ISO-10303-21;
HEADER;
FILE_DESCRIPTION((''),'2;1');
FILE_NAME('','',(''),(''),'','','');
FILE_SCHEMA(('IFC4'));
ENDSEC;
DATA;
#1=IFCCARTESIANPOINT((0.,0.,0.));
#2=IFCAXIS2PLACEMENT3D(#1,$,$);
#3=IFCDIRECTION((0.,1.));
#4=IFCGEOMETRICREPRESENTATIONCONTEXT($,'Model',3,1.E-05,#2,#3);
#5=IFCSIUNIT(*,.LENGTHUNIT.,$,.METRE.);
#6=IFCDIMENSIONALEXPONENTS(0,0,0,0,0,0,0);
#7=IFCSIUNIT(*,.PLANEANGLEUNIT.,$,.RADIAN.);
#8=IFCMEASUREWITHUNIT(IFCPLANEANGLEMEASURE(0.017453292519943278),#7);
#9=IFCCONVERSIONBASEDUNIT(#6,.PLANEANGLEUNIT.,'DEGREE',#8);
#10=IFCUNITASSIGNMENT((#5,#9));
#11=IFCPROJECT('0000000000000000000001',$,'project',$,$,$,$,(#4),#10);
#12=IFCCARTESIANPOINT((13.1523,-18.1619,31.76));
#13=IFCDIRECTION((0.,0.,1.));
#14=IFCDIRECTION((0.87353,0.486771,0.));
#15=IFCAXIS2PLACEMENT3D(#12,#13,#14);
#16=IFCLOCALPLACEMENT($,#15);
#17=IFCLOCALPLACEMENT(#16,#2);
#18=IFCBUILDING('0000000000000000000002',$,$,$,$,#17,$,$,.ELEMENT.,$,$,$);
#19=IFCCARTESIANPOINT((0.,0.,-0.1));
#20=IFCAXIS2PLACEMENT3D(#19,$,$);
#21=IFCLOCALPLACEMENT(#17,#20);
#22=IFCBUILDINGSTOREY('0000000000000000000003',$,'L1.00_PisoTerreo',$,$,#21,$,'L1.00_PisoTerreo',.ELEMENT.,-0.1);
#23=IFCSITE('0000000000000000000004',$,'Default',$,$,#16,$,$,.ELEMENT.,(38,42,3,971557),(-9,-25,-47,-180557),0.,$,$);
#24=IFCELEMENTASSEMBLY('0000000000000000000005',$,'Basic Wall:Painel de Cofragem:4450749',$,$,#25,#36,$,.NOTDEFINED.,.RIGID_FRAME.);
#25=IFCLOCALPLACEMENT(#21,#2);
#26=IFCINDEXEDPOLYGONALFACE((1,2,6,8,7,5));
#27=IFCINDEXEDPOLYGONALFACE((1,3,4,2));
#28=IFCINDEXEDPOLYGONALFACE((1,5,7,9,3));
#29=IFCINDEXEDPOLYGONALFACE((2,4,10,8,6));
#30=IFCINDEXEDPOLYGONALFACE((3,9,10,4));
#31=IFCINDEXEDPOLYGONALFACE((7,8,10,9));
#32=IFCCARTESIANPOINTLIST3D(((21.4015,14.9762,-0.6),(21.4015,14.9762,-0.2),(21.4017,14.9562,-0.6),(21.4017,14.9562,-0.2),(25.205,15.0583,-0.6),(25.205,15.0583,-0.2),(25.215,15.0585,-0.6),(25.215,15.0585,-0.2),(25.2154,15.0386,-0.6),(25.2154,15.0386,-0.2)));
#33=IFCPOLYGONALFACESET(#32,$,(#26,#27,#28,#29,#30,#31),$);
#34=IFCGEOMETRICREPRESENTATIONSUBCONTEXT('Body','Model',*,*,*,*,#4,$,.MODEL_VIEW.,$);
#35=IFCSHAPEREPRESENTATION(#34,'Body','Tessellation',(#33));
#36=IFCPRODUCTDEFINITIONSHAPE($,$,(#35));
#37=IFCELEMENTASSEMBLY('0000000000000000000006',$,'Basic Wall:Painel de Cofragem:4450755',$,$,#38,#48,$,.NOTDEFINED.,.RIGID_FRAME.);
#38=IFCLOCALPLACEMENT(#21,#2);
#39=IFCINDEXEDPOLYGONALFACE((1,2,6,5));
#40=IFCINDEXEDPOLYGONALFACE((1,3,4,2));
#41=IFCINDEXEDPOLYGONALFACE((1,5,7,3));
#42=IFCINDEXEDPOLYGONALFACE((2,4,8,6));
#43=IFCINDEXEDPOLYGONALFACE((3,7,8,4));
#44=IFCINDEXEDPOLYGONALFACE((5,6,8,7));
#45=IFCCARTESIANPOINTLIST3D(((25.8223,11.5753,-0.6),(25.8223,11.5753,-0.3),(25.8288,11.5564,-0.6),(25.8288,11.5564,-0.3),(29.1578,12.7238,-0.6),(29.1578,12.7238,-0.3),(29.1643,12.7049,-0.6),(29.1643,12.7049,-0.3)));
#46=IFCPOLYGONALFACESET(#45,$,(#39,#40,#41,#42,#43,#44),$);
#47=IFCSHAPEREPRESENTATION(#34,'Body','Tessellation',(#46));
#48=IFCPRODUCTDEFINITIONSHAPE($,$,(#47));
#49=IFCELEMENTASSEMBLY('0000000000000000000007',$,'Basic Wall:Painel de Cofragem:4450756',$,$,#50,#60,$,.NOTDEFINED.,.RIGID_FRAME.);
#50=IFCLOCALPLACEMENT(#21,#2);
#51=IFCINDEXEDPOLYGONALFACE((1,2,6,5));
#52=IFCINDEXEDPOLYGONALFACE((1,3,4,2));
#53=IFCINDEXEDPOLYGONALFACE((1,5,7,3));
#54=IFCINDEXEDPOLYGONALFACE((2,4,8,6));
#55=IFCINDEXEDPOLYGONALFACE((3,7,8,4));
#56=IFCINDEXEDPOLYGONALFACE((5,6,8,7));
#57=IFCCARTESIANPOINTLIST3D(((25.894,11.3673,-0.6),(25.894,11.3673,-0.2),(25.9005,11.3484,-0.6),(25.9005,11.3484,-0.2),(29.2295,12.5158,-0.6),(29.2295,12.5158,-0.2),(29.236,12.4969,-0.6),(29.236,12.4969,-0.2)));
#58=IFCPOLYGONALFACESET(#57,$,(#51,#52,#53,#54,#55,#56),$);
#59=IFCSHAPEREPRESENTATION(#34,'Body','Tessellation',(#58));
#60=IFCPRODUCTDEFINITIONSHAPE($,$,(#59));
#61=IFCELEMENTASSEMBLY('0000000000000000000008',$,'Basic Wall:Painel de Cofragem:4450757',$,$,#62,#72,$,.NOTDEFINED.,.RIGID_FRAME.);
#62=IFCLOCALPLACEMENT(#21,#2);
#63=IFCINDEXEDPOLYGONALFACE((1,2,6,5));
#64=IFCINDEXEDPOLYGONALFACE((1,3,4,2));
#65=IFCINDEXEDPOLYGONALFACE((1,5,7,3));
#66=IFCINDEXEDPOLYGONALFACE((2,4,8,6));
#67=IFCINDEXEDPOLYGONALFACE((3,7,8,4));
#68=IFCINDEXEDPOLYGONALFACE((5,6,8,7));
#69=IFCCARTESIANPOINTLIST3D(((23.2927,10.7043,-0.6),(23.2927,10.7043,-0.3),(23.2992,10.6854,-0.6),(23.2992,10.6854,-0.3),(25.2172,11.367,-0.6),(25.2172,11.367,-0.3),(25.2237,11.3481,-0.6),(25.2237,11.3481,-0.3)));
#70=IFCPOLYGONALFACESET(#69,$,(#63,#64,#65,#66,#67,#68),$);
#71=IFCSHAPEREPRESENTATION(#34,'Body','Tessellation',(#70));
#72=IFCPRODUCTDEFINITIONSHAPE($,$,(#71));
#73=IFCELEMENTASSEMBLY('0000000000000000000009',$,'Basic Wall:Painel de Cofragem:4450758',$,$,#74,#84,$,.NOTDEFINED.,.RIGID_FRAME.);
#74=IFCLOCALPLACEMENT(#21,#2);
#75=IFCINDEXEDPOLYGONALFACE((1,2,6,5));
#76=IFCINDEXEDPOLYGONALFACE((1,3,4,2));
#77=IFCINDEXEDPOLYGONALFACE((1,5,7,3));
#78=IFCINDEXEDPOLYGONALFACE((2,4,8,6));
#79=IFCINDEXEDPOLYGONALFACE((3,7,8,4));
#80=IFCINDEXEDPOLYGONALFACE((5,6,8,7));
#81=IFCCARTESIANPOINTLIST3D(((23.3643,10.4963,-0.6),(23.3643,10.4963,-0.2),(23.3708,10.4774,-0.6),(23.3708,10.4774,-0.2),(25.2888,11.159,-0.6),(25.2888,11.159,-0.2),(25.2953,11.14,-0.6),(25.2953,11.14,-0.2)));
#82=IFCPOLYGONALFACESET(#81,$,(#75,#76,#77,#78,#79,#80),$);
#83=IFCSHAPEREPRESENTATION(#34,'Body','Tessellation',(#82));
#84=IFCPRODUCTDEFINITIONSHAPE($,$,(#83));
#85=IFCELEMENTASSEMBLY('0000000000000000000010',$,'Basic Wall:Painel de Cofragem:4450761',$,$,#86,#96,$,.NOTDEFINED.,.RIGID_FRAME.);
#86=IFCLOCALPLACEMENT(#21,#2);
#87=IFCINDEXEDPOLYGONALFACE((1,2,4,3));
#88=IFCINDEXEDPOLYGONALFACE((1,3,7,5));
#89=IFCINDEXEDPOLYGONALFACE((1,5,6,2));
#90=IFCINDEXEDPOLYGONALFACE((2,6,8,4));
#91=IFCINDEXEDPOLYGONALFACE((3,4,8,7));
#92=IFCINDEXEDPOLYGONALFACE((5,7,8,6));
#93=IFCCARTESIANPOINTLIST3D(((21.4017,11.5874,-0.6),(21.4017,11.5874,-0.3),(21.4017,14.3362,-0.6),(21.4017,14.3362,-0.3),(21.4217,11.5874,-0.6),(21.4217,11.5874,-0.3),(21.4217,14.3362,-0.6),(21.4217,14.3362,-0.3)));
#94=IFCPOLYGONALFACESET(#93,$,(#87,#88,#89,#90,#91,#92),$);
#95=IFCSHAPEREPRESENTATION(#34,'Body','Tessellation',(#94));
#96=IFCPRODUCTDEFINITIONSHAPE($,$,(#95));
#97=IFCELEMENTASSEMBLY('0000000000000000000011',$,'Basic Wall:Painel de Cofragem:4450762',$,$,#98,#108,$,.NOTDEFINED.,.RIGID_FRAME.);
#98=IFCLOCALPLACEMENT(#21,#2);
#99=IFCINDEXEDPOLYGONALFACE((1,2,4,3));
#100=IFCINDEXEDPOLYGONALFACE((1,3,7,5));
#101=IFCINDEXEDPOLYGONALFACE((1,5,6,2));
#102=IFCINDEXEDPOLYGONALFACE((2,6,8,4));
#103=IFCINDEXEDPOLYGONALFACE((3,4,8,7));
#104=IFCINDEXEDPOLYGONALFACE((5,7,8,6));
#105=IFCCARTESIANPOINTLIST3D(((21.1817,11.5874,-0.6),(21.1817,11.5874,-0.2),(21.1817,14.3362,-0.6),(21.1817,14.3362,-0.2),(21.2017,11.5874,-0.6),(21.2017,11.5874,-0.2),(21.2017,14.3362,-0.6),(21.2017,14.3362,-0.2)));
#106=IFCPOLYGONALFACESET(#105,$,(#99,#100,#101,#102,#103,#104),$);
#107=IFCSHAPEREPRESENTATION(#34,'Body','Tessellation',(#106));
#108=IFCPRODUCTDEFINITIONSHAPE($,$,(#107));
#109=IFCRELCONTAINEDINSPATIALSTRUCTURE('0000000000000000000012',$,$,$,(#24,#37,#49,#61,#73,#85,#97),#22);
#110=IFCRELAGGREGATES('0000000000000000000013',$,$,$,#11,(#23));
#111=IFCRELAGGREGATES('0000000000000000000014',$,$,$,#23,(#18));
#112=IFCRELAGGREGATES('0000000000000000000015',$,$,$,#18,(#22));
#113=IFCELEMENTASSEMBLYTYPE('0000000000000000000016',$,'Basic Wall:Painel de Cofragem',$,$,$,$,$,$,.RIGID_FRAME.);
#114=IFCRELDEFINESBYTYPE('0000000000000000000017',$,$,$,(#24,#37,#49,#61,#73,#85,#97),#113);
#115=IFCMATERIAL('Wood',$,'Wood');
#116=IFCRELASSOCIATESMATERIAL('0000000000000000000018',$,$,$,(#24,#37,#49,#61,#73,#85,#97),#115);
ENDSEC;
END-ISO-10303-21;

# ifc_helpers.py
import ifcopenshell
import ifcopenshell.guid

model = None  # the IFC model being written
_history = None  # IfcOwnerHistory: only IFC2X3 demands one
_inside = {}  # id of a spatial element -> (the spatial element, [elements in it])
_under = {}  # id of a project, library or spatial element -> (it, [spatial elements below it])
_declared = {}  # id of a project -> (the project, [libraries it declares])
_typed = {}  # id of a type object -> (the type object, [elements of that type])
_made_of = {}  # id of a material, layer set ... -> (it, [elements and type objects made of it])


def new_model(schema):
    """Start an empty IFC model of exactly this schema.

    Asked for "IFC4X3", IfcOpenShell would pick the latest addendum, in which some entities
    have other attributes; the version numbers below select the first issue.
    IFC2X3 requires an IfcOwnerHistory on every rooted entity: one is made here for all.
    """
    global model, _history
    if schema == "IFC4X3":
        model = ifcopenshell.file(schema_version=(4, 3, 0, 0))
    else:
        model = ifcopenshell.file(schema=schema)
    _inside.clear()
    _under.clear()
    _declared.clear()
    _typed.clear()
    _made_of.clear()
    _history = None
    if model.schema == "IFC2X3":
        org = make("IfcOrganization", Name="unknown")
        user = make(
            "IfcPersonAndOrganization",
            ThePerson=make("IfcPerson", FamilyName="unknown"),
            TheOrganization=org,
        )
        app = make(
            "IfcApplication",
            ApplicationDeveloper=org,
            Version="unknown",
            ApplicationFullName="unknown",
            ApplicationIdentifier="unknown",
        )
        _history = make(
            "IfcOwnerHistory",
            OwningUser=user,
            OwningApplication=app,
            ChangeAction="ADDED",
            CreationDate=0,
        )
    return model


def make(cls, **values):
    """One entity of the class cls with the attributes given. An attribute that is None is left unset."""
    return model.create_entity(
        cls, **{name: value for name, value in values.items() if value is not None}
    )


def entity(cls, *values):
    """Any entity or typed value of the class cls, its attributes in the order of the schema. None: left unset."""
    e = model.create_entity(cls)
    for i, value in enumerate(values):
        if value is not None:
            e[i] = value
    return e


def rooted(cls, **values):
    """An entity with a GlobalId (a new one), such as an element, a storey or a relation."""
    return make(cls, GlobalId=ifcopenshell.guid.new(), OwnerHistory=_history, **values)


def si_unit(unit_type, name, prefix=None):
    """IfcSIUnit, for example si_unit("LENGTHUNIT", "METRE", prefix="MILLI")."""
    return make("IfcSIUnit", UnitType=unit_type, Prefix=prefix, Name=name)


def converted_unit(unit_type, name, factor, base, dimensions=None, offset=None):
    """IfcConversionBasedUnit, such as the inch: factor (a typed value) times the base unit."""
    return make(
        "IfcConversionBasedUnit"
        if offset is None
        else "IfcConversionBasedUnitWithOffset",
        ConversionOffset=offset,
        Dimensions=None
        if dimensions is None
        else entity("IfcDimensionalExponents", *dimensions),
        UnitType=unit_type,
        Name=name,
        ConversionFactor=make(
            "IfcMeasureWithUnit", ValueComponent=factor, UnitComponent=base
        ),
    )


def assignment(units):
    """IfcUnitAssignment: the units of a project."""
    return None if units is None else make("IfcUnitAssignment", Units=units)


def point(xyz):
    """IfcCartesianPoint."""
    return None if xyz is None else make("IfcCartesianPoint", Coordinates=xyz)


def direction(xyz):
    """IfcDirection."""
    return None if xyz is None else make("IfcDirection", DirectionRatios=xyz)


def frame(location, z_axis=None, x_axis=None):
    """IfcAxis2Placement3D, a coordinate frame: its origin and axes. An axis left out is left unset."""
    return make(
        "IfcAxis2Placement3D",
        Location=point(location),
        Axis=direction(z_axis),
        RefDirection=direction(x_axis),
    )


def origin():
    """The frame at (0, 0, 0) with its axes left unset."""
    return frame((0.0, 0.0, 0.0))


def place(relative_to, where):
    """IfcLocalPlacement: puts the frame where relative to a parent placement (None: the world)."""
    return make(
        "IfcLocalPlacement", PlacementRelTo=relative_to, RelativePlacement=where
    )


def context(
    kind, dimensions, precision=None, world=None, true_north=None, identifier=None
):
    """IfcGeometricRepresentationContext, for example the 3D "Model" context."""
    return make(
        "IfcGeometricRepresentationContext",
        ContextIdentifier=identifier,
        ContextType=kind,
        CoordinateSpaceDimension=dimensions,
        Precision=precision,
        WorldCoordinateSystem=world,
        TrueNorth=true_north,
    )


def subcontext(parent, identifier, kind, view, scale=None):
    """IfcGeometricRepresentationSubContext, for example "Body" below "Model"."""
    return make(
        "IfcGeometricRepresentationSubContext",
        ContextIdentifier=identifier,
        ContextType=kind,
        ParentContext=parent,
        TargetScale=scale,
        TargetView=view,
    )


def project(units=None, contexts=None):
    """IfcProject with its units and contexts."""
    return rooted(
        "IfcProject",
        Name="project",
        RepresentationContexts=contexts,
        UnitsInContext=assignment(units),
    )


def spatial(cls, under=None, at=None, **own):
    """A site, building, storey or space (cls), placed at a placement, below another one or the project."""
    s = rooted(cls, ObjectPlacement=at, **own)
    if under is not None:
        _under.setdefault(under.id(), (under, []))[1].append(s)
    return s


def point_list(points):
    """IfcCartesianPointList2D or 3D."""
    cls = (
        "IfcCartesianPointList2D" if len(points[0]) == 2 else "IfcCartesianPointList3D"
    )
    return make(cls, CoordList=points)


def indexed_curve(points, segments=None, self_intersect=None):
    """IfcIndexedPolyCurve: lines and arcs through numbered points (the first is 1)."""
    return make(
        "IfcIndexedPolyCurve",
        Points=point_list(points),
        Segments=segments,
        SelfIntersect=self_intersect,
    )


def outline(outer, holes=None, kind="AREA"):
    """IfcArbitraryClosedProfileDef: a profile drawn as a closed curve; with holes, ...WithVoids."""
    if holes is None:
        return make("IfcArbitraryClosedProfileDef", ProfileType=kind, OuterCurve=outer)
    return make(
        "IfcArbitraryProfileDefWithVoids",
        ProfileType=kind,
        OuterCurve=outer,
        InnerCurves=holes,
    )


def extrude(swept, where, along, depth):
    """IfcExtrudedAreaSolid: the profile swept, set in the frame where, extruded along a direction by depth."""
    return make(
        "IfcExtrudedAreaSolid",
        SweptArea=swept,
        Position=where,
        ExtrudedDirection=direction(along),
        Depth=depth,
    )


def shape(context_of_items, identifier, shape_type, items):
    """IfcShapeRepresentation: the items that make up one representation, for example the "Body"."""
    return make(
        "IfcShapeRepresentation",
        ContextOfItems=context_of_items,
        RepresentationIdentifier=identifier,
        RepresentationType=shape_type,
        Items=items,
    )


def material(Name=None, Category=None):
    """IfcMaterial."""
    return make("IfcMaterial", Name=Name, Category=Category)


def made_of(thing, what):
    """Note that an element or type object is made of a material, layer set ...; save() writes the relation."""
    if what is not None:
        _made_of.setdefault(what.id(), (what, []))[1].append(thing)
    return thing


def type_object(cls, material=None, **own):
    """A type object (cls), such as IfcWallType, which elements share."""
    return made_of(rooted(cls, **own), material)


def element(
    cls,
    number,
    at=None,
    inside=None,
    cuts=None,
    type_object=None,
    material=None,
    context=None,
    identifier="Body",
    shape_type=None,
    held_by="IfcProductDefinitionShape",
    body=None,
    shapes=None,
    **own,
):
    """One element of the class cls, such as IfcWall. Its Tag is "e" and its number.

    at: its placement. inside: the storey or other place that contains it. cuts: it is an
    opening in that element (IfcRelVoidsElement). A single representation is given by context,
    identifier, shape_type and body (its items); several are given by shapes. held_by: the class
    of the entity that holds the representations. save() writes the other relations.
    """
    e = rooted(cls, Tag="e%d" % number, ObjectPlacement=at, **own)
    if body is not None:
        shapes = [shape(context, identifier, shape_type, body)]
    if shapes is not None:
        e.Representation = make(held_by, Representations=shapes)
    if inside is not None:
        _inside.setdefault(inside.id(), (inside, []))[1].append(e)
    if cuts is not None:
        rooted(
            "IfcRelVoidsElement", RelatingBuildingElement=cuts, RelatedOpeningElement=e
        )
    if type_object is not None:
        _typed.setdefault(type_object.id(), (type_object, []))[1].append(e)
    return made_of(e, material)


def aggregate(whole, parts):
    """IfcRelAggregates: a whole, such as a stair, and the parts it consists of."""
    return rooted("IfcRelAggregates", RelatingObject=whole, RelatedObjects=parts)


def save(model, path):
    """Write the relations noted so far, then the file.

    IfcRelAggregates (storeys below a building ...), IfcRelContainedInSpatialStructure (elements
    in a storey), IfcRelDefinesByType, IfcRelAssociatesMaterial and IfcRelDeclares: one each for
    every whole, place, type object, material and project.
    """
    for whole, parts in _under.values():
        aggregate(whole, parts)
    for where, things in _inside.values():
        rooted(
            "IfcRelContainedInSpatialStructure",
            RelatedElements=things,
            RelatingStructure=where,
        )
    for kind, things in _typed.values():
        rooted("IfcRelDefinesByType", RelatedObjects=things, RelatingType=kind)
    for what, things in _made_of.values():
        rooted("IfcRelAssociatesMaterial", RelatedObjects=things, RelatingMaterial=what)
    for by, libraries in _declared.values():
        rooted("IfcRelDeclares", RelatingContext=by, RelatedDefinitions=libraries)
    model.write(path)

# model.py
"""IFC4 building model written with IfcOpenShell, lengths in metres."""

from ifc_helpers import new_model, entity, si_unit, converted_unit, direction, frame, origin, place, context, subcontext, project, spatial, indexed_curve, outline, extrude, material, type_object, element, save


model = new_model("IFC4")

# Units and contexts
model_context = context("Model", 3, precision=1e-05, world=origin(), true_north=direction((0.0, 1.0)))
body_context = subcontext(model_context, "Body", "Model", "MODEL_VIEW")
ifc_project = project(units=[si_unit("LENGTHUNIT", "METRE"), converted_unit("PLANEANGLEUNIT", "DEGREE", entity("IfcPlaneAngleMeasure", 0.017453292519943278), si_unit("PLANEANGLEUNIT", "RADIAN"), dimensions=[0, 0, 0, 0, 0, 0, 0])], contexts=[model_context])

# Site, building, storey
site_placement = place(None, frame((13.1523, -18.1619, 31.76), z_axis=(0.0, 0.0, 1.0), x_axis=(0.87353, 0.486771, 0.0)))
site = spatial("IfcSite", under=ifc_project, at=site_placement, Name="Default", CompositionType="ELEMENT", RefLatitude=(38, 42, 3, 971557), RefLongitude=(-9, -25, -47, -180557), RefElevation=0.0)
building_placement = place(site_placement, origin())
building = spatial("IfcBuilding", under=site, at=building_placement, CompositionType="ELEMENT")
storey_placement = place(building_placement, frame((0.0, 0.0, -0.1)))
storey = spatial("IfcBuildingStorey", under=building, at=storey_placement, Name="L1.00_PisoTerreo", LongName="L1.00_PisoTerreo", CompositionType="ELEMENT", Elevation=-0.1)

# Element assemblies
ifc_material_1 = material(Name="Wood", Category="Wood")
element_assembly_type = type_object("IfcElementAssemblyType", Name="Basic Wall:Painel de Cofragem", PredefinedType="RIGID_FRAME")
assembly_1_placement = place(storey_placement, frame((21.4015, 14.9662, -0.6), z_axis=(0.0, 0.0, 1.0), x_axis=(0.999767, 0.021581, 0.0)))
element("IfcElementAssembly", 1, at=assembly_1_placement, inside=storey, type_object=element_assembly_type, material=ifc_material_1, Name="Basic Wall:Painel de Cofragem:4450749", AssemblyPlace="NOTDEFINED", PredefinedType="RIGID_FRAME", context=body_context, shape_type="SweptSolid", body=[
    extrude(outline(indexed_curve([(3.8146, -0.01), (3.8146, 0.01), (3.8046, 0.01), (0.0002, 0.01), (0.0, -0.01), (3.8146, -0.01)], self_intersect=False)), origin(), (0.0, 0.0, 1.0), 0.4),
])
assembly_2_placement = place(storey_placement, frame((25.8256, 11.5659, -0.6), z_axis=(0.0, 0.0, 1.0), x_axis=(0.945519, 0.325568, 0.0)))
element("IfcElementAssembly", 2, at=assembly_2_placement, inside=storey, type_object=element_assembly_type, material=ifc_material_1, Name="Basic Wall:Painel de Cofragem:4450755", AssemblyPlace="NOTDEFINED", PredefinedType="RIGID_FRAME", context=body_context, shape_type="SweptSolid", body=[
    extrude(outline(indexed_curve([(3.5277, 0.01), (0.0, 0.01), (0.0, -0.01), (3.5277, -0.01), (3.5277, 0.01)], self_intersect=False)), origin(), (0.0, 0.0, 1.0), 0.3),
])
assembly_3_placement = place(storey_placement, frame((25.8972, 11.3579, -0.6), z_axis=(0.0, 0.0, 1.0), x_axis=(0.945519, 0.325568, 0.0)))
element("IfcElementAssembly", 3, at=assembly_3_placement, inside=storey, type_object=element_assembly_type, material=ifc_material_1, Name="Basic Wall:Painel de Cofragem:4450756", AssemblyPlace="NOTDEFINED", PredefinedType="RIGID_FRAME", context=body_context, shape_type="SweptSolid", body=[
    extrude(outline(indexed_curve([(3.5277, 0.01), (0.0, 0.01), (0.0, -0.01), (3.5277, -0.01), (3.5277, 0.01)], self_intersect=False)), origin(), (0.0, 0.0, 1.0), 0.4),
])
assembly_4_placement = place(storey_placement, frame((23.2959, 10.6949, -0.6), z_axis=(0.0, 0.0, 1.0), x_axis=(0.945519, 0.325568, 0.0)))
element("IfcElementAssembly", 4, at=assembly_4_placement, inside=storey, type_object=element_assembly_type, material=ifc_material_1, Name="Basic Wall:Painel de Cofragem:4450757", AssemblyPlace="NOTDEFINED", PredefinedType="RIGID_FRAME", context=body_context, shape_type="SweptSolid", body=[
    extrude(outline(indexed_curve([(2.0354, 0.01), (0.0, 0.01), (0.0, -0.01), (2.0354, -0.01), (2.0354, 0.01)], self_intersect=False)), origin(), (0.0, 0.0, 1.0), 0.3),
])
assembly_5_placement = place(storey_placement, frame((23.3676, 10.4868, -0.6), z_axis=(0.0, 0.0, 1.0), x_axis=(0.945519, 0.325568, 0.0)))
element("IfcElementAssembly", 5, at=assembly_5_placement, inside=storey, type_object=element_assembly_type, material=ifc_material_1, Name="Basic Wall:Painel de Cofragem:4450758", AssemblyPlace="NOTDEFINED", PredefinedType="RIGID_FRAME", context=body_context, shape_type="SweptSolid", body=[
    extrude(outline(indexed_curve([(2.0354, 0.01), (0.0, 0.01), (0.0, -0.01), (2.0354, -0.01), (2.0354, 0.01)], self_intersect=False)), origin(), (0.0, 0.0, 1.0), 0.4),
])
assembly_6_placement = place(storey_placement, frame((21.4117, 11.5874, -0.6), z_axis=(0.0, 0.0, 1.0), x_axis=(0.0, 1.0, 0.0)))
element("IfcElementAssembly", 6, at=assembly_6_placement, inside=storey, type_object=element_assembly_type, material=ifc_material_1, Name="Basic Wall:Painel de Cofragem:4450761", AssemblyPlace="NOTDEFINED", PredefinedType="RIGID_FRAME", context=body_context, shape_type="SweptSolid", body=[
    extrude(outline(indexed_curve([(2.7488, 0.01), (0.0, 0.01), (0.0, -0.01), (2.7488, -0.01), (2.7488, 0.01)], self_intersect=False)), origin(), (0.0, 0.0, 1.0), 0.3),
])
assembly_7_placement = place(storey_placement, frame((21.1917, 11.5874, -0.6), z_axis=(0.0, 0.0, 1.0), x_axis=(0.0, 1.0, 0.0)))
element("IfcElementAssembly", 7, at=assembly_7_placement, inside=storey, type_object=element_assembly_type, material=ifc_material_1, Name="Basic Wall:Painel de Cofragem:4450762", AssemblyPlace="NOTDEFINED", PredefinedType="RIGID_FRAME", context=body_context, shape_type="SweptSolid", body=[
    extrude(outline(indexed_curve([(2.7488, 0.01), (0.0, 0.01), (0.0, -0.01), (2.7488, -0.01), (2.7488, 0.01)], self_intersect=False)), origin(), (0.0, 0.0, 1.0), 0.4),
])

save(model, "model.ifc")
